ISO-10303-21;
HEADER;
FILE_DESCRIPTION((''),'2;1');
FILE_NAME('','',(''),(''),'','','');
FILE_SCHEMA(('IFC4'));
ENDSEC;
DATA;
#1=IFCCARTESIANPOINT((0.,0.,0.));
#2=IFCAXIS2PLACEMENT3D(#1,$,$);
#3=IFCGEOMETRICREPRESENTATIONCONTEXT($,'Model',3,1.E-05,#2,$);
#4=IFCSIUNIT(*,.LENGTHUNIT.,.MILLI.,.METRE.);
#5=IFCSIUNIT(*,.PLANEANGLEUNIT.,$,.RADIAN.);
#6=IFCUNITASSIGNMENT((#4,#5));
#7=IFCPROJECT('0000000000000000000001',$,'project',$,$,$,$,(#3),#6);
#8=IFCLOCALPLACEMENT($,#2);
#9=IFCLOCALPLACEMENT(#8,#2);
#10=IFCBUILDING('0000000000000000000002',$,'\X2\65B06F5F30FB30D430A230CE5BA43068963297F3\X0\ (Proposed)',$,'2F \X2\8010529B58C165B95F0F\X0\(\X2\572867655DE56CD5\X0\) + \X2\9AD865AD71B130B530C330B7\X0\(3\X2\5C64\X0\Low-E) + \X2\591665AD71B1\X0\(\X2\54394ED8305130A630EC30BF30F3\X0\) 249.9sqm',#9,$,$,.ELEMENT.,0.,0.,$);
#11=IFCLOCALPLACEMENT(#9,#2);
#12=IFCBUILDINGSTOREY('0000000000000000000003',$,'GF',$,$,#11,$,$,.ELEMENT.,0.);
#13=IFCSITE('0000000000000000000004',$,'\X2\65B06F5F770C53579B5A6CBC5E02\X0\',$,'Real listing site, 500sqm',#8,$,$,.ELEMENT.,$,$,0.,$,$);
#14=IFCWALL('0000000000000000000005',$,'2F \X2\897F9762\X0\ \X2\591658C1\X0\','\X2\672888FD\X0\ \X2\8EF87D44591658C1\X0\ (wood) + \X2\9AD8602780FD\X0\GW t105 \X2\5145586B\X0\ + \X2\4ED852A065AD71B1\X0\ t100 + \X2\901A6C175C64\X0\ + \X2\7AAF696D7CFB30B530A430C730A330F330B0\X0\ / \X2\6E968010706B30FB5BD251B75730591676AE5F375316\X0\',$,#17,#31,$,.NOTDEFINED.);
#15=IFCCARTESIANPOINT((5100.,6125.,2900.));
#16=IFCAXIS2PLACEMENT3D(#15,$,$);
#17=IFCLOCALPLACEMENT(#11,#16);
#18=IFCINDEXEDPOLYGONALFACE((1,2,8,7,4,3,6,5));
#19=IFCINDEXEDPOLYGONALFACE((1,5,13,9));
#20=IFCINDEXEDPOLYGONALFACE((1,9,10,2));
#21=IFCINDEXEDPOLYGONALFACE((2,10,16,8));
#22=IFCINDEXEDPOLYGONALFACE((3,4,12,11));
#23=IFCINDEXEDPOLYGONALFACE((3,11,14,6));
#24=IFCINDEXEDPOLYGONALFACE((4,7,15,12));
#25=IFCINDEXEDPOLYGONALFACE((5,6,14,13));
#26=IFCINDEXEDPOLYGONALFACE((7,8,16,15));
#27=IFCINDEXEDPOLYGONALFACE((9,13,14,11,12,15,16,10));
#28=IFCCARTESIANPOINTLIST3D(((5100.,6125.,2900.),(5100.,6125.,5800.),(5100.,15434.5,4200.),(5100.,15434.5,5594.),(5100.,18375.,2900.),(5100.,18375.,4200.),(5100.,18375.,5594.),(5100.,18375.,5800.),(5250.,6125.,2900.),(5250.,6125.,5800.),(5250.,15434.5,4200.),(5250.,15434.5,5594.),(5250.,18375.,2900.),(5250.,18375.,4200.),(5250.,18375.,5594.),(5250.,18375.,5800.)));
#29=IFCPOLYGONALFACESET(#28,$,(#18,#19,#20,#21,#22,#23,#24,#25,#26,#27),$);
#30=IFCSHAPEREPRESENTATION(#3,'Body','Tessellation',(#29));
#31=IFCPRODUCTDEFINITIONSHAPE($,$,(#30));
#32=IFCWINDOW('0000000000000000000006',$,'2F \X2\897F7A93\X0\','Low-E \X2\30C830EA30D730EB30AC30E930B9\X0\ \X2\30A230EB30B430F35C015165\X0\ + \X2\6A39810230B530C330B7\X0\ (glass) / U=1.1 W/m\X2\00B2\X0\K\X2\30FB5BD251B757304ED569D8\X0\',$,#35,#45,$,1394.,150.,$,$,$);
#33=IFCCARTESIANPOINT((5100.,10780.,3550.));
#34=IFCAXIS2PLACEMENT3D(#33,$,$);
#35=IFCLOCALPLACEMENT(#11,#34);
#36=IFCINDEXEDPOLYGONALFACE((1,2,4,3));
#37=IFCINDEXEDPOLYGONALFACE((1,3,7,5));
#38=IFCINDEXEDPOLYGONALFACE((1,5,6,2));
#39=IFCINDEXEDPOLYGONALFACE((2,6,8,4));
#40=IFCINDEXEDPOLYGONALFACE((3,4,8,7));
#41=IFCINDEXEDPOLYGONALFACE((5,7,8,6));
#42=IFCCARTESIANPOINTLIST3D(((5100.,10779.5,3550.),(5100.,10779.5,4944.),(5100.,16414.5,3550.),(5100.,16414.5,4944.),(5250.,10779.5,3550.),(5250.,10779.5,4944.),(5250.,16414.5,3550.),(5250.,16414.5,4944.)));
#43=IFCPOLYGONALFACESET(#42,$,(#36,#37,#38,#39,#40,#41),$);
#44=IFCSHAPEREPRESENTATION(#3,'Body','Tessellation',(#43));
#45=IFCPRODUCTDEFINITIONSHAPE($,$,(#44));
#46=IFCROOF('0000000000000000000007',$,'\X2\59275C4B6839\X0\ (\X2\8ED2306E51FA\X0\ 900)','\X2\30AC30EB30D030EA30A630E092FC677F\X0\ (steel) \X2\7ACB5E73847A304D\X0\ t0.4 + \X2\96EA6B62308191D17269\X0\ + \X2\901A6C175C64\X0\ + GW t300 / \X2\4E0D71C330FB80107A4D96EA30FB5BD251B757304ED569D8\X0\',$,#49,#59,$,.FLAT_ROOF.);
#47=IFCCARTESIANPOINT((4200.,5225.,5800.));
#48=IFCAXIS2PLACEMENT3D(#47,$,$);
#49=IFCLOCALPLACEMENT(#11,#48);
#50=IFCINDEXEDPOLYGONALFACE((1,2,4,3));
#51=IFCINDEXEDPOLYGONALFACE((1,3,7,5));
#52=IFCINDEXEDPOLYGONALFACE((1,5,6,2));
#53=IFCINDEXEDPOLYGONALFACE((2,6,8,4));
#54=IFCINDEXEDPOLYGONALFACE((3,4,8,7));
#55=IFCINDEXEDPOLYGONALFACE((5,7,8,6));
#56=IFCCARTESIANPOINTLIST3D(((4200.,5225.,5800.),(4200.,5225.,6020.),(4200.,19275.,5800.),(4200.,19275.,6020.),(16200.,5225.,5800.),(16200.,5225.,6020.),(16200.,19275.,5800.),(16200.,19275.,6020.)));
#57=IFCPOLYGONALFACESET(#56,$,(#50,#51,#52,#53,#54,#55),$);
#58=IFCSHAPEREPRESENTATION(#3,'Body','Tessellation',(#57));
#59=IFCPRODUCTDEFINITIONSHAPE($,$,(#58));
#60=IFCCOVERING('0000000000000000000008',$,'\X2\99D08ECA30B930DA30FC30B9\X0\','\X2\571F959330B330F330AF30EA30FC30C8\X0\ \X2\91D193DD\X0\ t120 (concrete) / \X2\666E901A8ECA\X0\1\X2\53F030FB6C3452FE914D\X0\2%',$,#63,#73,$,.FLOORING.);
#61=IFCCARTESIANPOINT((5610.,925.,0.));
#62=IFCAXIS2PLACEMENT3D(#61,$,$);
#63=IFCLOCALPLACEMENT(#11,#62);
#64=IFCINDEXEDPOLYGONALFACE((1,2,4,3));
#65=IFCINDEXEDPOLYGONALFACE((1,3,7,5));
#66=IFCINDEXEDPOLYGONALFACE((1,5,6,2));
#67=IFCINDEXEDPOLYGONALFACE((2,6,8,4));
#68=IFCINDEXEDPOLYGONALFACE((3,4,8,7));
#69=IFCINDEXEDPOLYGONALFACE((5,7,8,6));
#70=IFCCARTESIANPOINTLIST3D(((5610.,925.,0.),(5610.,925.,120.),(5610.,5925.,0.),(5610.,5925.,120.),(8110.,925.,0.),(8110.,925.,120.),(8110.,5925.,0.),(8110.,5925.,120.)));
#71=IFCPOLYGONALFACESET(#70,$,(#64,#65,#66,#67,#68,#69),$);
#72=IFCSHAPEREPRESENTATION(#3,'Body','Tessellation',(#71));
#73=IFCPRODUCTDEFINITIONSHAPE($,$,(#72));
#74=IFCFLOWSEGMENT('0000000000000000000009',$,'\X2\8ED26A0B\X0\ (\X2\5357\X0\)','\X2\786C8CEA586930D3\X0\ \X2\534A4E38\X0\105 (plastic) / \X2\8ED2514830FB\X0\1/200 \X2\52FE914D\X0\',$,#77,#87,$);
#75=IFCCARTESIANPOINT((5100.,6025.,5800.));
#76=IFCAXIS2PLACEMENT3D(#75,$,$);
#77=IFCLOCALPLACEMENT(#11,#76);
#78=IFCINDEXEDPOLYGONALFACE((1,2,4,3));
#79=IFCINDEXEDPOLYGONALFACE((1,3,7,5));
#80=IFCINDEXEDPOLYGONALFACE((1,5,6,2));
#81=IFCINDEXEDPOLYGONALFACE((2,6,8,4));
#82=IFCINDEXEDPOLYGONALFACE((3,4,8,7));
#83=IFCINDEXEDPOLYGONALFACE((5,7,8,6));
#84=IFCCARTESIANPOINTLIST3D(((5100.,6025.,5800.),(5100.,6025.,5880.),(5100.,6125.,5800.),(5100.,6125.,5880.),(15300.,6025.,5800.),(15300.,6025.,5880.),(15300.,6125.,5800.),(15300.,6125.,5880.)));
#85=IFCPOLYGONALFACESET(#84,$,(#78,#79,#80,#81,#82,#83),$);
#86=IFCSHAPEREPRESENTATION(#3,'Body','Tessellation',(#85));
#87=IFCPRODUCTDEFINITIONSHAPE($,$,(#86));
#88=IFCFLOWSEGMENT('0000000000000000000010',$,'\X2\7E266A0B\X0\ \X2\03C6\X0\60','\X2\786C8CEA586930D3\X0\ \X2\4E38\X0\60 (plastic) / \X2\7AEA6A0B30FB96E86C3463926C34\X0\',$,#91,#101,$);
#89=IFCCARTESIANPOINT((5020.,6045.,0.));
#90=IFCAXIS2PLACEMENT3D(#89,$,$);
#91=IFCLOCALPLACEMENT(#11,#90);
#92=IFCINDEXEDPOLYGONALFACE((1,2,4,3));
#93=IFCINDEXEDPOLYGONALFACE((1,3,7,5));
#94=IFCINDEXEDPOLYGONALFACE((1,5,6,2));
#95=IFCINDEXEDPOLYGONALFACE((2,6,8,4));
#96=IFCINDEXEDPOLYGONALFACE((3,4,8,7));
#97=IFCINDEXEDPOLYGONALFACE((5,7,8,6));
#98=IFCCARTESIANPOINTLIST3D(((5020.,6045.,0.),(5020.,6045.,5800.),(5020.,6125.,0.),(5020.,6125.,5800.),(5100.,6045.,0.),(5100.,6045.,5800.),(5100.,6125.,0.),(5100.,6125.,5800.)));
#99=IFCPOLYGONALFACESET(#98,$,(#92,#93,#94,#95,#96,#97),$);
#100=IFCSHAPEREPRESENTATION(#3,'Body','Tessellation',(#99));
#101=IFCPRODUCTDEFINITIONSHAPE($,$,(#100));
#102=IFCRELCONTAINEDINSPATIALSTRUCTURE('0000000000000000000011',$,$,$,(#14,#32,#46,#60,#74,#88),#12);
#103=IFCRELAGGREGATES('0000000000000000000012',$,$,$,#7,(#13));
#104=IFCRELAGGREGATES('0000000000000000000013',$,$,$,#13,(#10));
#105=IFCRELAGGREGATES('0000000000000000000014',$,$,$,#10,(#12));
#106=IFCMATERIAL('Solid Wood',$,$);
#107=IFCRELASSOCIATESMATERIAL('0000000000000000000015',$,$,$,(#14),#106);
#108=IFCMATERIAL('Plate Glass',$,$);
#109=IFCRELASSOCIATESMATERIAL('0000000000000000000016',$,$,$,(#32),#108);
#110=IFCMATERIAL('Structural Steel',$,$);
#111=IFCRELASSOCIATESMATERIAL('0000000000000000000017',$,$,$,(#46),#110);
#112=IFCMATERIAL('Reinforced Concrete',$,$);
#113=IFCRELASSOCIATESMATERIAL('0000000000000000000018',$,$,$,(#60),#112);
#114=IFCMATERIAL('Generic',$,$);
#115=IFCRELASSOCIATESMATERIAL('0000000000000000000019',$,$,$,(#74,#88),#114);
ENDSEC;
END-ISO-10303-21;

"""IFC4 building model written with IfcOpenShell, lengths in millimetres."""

from ifc_helpers import new_model, si_unit, frame, frame_2d, origin, place, context, project, spatial, rectangle, extrude, material, element, fill, save


model = new_model("IFC4")

# Units and contexts
model_context = context("Model", 3, precision=1e-05, world=origin())
ifc_project = project(units=[si_unit("LENGTHUNIT", "METRE", prefix="MILLI"), si_unit("PLANEANGLEUNIT", "RADIAN")], contexts=[model_context])

# Site, building, storey
site_placement = place(None, origin())
site = spatial("IfcSite", under=ifc_project, at=site_placement, Name="新潟県南魚沼市", ObjectType="Real listing site, 500sqm", CompositionType="ELEMENT", RefElevation=0.0)
building_placement = place(site_placement, origin())
building = spatial("IfcBuilding", under=site, at=building_placement, Name="新潟・ピアノ室と防音 (Proposed)", ObjectType="2F 耐力壁方式(在来工法) + 高断熱サッシ(3層Low-E) + 外断熱(吹付けウレタン) 249.9sqm", CompositionType="ELEMENT", ElevationOfRefHeight=0.0, ElevationOfTerrain=0.0)
storey_placement = place(building_placement, origin())
storey = spatial("IfcBuildingStorey", under=building, at=storey_placement, Name="GF", CompositionType="ELEMENT", Elevation=0.0)

# Shared definitions
ifc_material_1 = material(Name="Solid Wood")

# Shared definitions
ifc_material_2 = material(Name="Reinforced Concrete")

# Shared definitions
ifc_material_3 = material(Name="Plate Glass")

# Wall, opening, window
wall_1_placement = place(storey_placement, frame((5100.0, 6125.0, 2900.0)))
wall_1 = element("IfcWall", 1, at=wall_1_placement, inside=storey, material=ifc_material_1, Name="2F 西面 外壁", Description="木製 軸組外壁 (wood) + 高性能GW t105 充填 + 付加断熱 t100 + 通気層 + 窯業系サイディング / 準耐火・寒冷地外皮強化", PredefinedType="NOTDEFINED", context=model_context, shape_type="SweptSolid", body=[
    extrude(rectangle(XDim=150.0, YDim=12250.0, at=frame_2d((75.0, 6125.0))), frame((5100.0, 6125.0, 2900.0)), (0.0, 0.0, 1.0), 2900.0),
])
opening_1_placement = place(storey_placement, frame((5100.0, 10780.0, 3550.0)))
opening_1 = element("IfcOpeningElement", 2, at=opening_1_placement, cuts=wall_1, PredefinedType="NOTDEFINED", context=model_context, shape_type="SweptSolid", body=[
    extrude(rectangle(XDim=150.0, YDim=5635.0, at=frame_2d((75.0, 2817.0))), frame((5100.0, 10780.0, 3550.0)), (0.0, 0.0, 1.0), 1394.0),
])
window_1_placement = place(storey_placement, frame((5100.0, 10780.0, 3550.0)))
window_1 = element("IfcWindow", 3, at=window_1_placement, inside=storey, material=ifc_material_3, Name="2F 西窓", Description="Low-E トリプルガラス アルゴン封入 + 樹脂サッシ (glass) / U=1.1 W/m²K・寒冷地仕様", OverallHeight=1394.0, OverallWidth=150.0, context=model_context, shape_type="SweptSolid", body=[
    extrude(rectangle(XDim=150.0, YDim=5635.0, at=frame_2d((75.0, 2817.0))), frame((5100.0, 10780.0, 3550.0)), (0.0, 0.0, 1.0), 1394.0),
])
fill(opening_1, window_1)

# Roof
ifc_material_4 = material(Name="Structural Steel")
roof_placement = place(storey_placement, frame((4200.0, 5225.0, 5800.0)))
element("IfcRoof", 4, at=roof_placement, inside=storey, material=ifc_material_4, Name="大屋根 (軒の出 900)", Description="ガルバリウム鋼板 (steel) 立平葺き t0.4 + 雪止め金物 + 通気層 + GW t300 / 不燃・耐積雪・寒冷地仕様", PredefinedType="FLAT_ROOF", context=model_context, shape_type="SweptSolid", body=[
    extrude(rectangle(XDim=12000.0, YDim=14050.0, at=frame_2d((6000.0, 7025.0))), frame((4200.0, 5225.0, 5800.0)), (0.0, 0.0, 1.0), 220.0),
])

# Covering
covering_placement = place(storey_placement, frame((5610.0, 925.0, 0.0)))
element("IfcCovering", 5, at=covering_placement, inside=storey, material=ifc_material_2, Name="駐車スペース", Description="土間コンクリート 金鏝 t120 (concrete) / 普通車1台・水勾配2%", PredefinedType="FLOORING", context=model_context, shape_type="SweptSolid", body=[
    extrude(rectangle(XDim=2500.0, YDim=5000.0, at=frame_2d((1250.0, 2500.0))), frame((5610.0, 925.0, 0.0)), (0.0, 0.0, 1.0), 120.0),
])

# Flow segments
ifc_material_5 = material(Name="Generic")
flow_segment_1_placement = place(storey_placement, frame((5100.0, 6025.0, 5800.0)))
element("IfcFlowSegment", 6, at=flow_segment_1_placement, inside=storey, material=ifc_material_5, Name="軒樋 (南)", Description="硬質塩ビ 半丸105 (plastic) / 軒先・1/200 勾配", context=model_context, shape_type="SweptSolid", body=[
    extrude(rectangle(XDim=10200.0, YDim=100.0, at=frame_2d((5100.0, 50.0))), frame((5100.0, 6025.0, 5800.0)), (0.0, 0.0, 1.0), 80.0),
])
flow_segment_2_placement = place(storey_placement, frame((5020.0, 6045.0, 0.0)))
element("IfcFlowSegment", 7, at=flow_segment_2_placement, inside=storey, material=ifc_material_5, Name="縦樋 φ60", Description="硬質塩ビ 丸60 (plastic) / 竪樋・雨水排水", context=model_context, shape_type="SweptSolid", body=[
    extrude(rectangle(XDim=80.0, YDim=80.0, at=frame_2d((40.0, 40.0))), frame((5020.0, 6045.0, 0.0)), (0.0, 0.0, 1.0), 5800.0),
])

save(model, "model.ifc")
